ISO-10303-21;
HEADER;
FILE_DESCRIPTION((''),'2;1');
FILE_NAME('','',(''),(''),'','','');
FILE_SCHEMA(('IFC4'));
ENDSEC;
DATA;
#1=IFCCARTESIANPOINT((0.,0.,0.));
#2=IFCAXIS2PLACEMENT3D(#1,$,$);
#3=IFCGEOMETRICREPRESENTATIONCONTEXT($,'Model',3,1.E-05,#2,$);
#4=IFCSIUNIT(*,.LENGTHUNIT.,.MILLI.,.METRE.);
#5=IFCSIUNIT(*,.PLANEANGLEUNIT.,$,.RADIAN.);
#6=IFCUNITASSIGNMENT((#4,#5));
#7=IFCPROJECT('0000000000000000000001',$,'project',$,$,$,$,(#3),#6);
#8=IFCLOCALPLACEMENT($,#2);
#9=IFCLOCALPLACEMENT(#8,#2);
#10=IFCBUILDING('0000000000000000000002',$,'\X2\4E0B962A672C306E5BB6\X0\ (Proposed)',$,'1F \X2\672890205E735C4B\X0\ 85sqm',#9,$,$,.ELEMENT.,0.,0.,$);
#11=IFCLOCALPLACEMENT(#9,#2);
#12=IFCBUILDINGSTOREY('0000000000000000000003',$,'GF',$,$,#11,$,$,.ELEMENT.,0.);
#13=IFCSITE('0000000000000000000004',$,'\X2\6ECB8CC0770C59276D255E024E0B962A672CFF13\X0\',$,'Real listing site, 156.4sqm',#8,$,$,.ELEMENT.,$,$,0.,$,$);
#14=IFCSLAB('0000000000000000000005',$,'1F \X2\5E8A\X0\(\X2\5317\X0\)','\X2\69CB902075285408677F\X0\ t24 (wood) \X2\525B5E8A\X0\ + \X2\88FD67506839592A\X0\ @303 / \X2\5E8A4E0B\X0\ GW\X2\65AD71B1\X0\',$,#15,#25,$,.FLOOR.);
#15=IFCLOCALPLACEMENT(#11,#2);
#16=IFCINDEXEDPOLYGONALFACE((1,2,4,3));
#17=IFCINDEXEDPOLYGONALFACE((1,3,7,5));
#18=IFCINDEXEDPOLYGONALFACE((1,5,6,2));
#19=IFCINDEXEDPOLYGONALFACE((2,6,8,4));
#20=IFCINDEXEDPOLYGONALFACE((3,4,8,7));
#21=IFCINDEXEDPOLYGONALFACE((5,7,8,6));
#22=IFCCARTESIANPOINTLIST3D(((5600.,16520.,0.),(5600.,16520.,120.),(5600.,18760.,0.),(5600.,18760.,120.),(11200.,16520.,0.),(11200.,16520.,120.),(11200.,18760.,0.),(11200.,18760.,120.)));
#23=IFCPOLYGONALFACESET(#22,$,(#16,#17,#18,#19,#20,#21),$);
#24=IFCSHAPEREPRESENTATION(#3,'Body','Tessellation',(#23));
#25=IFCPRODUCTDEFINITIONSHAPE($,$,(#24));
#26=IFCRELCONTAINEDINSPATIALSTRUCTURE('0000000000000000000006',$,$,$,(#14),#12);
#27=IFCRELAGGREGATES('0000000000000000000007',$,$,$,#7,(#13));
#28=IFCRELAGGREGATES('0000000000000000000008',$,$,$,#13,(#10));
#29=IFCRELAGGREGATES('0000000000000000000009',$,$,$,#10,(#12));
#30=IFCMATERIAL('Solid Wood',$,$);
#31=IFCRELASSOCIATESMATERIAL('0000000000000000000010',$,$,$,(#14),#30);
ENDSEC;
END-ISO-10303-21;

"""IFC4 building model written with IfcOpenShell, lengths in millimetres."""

from ifc_helpers import new_model, si_unit, frame, frame_2d, origin, place, context, project, spatial, rectangle, extrude, material, element, save


model = new_model("IFC4")

# Units and contexts
model_context = context("Model", 3, precision=1e-05, world=origin())
ifc_project = project(units=[si_unit("LENGTHUNIT", "METRE", prefix="MILLI"), si_unit("PLANEANGLEUNIT", "RADIAN")], contexts=[model_context])

# Site, building, storey
site_placement = place(None, origin())
site = spatial("IfcSite", under=ifc_project, at=site_placement, Name="滋賀県大津市下阪本３", ObjectType="Real listing site, 156.4sqm", CompositionType="ELEMENT", RefElevation=0.0)
building_placement = place(site_placement, origin())
building = spatial("IfcBuilding", under=site, at=building_placement, Name="下阪本の家 (Proposed)", ObjectType="1F 木造平屋 85sqm", CompositionType="ELEMENT", ElevationOfRefHeight=0.0, ElevationOfTerrain=0.0)
storey_placement = place(building_placement, origin())
storey = spatial("IfcBuildingStorey", under=building, at=storey_placement, Name="GF", CompositionType="ELEMENT", Elevation=0.0)

# Slab
ifc_material_1 = material(Name="Solid Wood")
slab_1_placement = place(storey_placement, frame((2800.0, 8260.0, 0.0)))
element("IfcSlab", 1, at=slab_1_placement, inside=storey, material=ifc_material_1, Name="1F 床(北)", Description="構造用合板 t24 (wood) 剛床 + 製材根太 @303 / 床下 GW断熱", PredefinedType="FLOOR", context=model_context, shape_type="SweptSolid", body=[
    extrude(rectangle(XDim=5600.0, YDim=2240.0, at=frame_2d((2800.0, 1120.0))), frame((2800.0, 8260.0, 0.0)), (0.0, 0.0, 1.0), 120.0),
])

save(model, "model.ifc")
